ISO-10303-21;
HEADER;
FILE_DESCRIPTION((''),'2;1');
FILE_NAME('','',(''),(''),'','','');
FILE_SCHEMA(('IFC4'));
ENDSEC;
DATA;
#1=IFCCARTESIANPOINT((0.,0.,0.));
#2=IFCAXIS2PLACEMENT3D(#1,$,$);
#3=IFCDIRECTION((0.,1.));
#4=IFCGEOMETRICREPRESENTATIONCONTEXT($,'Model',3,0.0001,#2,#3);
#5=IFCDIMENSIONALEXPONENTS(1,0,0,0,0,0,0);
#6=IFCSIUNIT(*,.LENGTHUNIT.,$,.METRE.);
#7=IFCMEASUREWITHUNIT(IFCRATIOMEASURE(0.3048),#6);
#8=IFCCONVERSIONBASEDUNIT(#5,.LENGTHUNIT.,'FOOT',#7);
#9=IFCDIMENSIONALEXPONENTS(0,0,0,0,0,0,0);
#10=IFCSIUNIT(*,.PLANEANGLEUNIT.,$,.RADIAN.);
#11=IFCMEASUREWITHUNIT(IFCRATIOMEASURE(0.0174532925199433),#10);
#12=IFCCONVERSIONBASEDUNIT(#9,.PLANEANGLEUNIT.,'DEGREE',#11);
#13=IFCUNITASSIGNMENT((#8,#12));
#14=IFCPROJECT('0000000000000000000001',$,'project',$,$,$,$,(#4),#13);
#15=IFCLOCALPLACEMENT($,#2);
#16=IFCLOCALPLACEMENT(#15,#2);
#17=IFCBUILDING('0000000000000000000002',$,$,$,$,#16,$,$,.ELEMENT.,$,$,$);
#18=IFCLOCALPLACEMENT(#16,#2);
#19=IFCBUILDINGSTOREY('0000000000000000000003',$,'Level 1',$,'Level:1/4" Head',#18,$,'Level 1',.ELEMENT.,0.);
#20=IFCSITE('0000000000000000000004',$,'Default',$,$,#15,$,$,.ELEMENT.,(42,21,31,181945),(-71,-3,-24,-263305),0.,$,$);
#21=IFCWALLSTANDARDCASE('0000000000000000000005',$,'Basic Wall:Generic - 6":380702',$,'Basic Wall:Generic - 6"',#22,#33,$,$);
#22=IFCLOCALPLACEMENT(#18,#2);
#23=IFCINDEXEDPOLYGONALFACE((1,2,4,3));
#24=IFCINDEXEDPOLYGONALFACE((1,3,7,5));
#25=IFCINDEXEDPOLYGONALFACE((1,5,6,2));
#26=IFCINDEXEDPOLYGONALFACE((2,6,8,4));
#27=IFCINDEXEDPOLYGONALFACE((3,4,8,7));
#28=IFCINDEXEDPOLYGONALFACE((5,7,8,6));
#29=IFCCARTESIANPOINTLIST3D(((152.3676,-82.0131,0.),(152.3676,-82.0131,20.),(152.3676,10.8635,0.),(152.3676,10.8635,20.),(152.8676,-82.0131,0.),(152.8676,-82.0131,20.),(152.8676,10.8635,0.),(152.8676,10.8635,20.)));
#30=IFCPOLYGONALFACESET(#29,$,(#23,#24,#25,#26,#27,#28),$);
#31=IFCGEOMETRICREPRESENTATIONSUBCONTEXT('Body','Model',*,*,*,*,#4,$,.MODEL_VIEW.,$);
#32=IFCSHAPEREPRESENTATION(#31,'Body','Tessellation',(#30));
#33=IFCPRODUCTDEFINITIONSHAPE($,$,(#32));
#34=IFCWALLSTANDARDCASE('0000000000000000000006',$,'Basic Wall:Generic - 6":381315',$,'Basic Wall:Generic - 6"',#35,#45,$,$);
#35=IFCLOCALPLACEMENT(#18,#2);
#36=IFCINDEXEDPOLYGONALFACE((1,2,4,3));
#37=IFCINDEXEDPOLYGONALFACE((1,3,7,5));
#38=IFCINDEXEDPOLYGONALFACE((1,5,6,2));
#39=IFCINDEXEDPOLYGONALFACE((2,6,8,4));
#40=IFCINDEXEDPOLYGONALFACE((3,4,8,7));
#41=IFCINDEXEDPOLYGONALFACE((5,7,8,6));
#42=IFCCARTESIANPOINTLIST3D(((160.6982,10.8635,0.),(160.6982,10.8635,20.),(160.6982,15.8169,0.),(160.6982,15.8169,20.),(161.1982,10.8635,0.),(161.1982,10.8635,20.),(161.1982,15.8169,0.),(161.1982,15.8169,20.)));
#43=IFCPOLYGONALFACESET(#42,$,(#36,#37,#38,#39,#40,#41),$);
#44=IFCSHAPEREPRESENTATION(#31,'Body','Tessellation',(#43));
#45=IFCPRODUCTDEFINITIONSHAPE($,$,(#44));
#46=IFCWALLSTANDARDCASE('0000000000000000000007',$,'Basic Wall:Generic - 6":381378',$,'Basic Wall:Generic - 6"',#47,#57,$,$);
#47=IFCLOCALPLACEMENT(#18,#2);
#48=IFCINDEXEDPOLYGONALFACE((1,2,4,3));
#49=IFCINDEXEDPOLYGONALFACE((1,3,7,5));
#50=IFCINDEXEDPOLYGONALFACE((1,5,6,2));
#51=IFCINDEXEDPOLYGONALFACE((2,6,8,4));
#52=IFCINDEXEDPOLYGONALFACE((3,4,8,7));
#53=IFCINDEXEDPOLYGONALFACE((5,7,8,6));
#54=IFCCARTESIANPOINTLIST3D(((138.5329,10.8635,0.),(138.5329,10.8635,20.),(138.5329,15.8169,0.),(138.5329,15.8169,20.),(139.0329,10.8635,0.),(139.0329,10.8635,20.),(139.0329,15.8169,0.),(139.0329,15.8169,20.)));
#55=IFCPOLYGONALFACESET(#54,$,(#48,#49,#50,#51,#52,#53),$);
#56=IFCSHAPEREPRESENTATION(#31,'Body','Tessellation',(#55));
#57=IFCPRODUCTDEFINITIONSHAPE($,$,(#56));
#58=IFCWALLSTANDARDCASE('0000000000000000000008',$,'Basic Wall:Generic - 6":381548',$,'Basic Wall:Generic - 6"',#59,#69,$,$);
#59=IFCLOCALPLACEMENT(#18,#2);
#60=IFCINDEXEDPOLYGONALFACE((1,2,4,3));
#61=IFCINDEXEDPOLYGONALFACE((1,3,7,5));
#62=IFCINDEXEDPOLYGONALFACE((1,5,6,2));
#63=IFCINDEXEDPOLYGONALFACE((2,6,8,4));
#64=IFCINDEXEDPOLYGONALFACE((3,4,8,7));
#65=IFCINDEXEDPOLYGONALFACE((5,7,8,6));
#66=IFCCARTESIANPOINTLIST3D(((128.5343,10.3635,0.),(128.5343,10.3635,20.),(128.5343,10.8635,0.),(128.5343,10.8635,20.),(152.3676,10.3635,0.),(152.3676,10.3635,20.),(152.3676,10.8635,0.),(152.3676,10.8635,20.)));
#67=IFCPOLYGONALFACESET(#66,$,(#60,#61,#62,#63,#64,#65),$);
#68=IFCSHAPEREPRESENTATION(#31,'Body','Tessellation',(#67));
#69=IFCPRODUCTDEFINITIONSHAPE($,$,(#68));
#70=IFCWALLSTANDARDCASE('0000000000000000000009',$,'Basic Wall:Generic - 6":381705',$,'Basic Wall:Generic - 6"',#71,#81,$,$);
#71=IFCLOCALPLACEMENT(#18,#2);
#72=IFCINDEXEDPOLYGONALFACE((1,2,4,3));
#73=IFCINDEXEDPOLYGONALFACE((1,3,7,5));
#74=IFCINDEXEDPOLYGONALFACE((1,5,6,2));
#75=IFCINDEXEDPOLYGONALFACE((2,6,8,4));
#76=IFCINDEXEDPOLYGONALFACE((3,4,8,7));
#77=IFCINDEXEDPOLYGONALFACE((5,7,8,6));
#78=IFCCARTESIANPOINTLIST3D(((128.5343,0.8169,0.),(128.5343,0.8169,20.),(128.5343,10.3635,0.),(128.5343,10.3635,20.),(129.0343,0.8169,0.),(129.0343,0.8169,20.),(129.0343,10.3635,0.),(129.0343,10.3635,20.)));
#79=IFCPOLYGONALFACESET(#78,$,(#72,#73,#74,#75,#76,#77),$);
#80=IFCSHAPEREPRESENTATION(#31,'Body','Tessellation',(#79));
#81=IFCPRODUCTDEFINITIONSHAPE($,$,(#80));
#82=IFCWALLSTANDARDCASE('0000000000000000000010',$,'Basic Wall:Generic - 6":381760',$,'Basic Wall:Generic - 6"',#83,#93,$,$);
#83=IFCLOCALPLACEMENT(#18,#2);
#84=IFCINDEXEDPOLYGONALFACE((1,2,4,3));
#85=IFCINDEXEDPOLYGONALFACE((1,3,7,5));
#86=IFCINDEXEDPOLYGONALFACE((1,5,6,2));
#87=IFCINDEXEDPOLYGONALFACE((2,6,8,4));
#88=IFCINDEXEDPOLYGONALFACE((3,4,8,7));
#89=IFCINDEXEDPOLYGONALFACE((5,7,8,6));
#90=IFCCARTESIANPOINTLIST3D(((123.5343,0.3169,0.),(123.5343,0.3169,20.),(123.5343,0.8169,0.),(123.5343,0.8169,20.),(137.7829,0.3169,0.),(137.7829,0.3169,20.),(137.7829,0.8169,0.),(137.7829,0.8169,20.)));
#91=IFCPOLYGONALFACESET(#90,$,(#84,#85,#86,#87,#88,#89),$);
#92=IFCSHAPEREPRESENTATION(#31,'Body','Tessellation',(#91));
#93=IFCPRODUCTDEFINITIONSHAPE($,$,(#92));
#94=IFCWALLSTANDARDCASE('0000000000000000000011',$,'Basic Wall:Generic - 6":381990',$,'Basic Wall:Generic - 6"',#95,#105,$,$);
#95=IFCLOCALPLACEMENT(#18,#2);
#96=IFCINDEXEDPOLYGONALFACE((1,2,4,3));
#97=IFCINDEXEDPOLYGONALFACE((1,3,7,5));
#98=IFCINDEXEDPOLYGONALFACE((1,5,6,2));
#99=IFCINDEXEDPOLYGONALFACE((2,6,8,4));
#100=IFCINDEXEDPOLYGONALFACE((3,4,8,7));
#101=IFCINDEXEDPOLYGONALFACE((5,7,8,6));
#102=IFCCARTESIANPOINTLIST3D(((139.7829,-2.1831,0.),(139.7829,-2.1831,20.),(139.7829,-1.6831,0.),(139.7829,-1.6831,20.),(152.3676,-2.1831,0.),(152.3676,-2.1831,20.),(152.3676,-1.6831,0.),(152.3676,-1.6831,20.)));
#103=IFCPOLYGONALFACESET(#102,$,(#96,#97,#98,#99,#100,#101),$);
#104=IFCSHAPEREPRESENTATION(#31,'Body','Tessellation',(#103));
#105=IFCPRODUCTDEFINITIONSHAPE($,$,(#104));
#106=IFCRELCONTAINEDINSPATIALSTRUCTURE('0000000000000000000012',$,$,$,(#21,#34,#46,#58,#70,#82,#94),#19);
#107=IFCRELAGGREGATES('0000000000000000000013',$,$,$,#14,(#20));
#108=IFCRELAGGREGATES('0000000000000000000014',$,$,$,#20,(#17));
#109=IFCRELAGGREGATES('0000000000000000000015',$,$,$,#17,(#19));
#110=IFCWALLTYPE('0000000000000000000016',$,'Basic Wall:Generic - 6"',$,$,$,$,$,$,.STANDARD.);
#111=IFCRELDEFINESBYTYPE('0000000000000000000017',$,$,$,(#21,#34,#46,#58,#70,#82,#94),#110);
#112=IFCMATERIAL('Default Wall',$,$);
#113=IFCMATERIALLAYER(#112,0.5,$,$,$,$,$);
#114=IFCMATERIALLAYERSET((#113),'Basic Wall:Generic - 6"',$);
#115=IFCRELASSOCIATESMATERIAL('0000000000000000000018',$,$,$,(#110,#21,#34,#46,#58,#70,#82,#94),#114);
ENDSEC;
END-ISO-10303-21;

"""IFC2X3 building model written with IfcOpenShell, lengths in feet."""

from ifc_helpers import new_model, entity, si_unit, converted_unit, direction, frame, frame_2d, origin, place, context, subcontext, project, spatial, rectangle, extrude, material, layer, layer_set, layer_usage, type_object, element, save


model = new_model("IFC2X3")

# Units and contexts
model_context = context("Model", 3, precision=0.0001, world=origin(), true_north=direction((0.0, 1.0)))
body_context = subcontext(model_context, "Body", "Model", "MODEL_VIEW")
ifc_project = project(units=[converted_unit("LENGTHUNIT", "FOOT", entity("IfcRatioMeasure", 0.3048), si_unit("LENGTHUNIT", "METRE"), dimensions=[1, 0, 0, 0, 0, 0, 0]), converted_unit("PLANEANGLEUNIT", "DEGREE", entity("IfcRatioMeasure", 0.0174532925199433), si_unit("PLANEANGLEUNIT", "RADIAN"), dimensions=[0, 0, 0, 0, 0, 0, 0])], contexts=[model_context])

# Site, building, storey
site_placement = place(None, origin())
site = spatial("IfcSite", under=ifc_project, at=site_placement, Name="Default", CompositionType="ELEMENT", RefLatitude=(42, 21, 31, 181945), RefLongitude=(-71, -3, -24, -263305), RefElevation=0.0)
building_placement = place(site_placement, origin())
building = spatial("IfcBuilding", under=site, at=building_placement, CompositionType="ELEMENT")
storey_placement = place(building_placement, origin())
storey = spatial("IfcBuildingStorey", under=building, at=storey_placement, Name="Level 1", ObjectType="Level:1/4\" Head", LongName="Level 1", CompositionType="ELEMENT", Elevation=0.0)

# Walls
ifc_material = material(Name="Default Wall")
ifc_layer_1 = layer(ifc_material, 0.5)
ifc_layer_set_1 = layer_set([ifc_layer_1], Name="Basic Wall:Generic - 6\"")
wall_type_1 = type_object("IfcWallType", Name="Basic Wall:Generic - 6\"", PredefinedType="STANDARD", material=ifc_layer_set_1)
ifc_layer_usage_1 = layer_usage(ifc_layer_set_1, "AXIS2", "NEGATIVE", 0.25)
wall_1_placement = place(storey_placement, frame((152.6176, 10.8635, 0.0), z_axis=(0.0, 0.0, 1.0), x_axis=(0.0, -1.0, 0.0)))
element("IfcWallStandardCase", 1, at=wall_1_placement, inside=storey, type_object=wall_type_1, material=ifc_layer_usage_1, Name="Basic Wall:Generic - 6\":380702", ObjectType="Basic Wall:Generic - 6\"", context=body_context, shape_type="SweptSolid", body=[
    extrude(rectangle(XDim=92.8766, YDim=0.5, at=frame_2d((46.4383, 0.0), x_axis=(-1.0, 0.0))), origin(), (0.0, 0.0, 1.0), 20.0),
])
ifc_layer_usage_2 = layer_usage(ifc_layer_set_1, "AXIS2", "NEGATIVE", 0.25)
wall_2_placement = place(storey_placement, frame((160.9482, 15.8169, 0.0), z_axis=(0.0, 0.0, 1.0), x_axis=(0.0, -1.0, 0.0)))
element("IfcWallStandardCase", 2, at=wall_2_placement, inside=storey, type_object=wall_type_1, material=ifc_layer_usage_2, Name="Basic Wall:Generic - 6\":381315", ObjectType="Basic Wall:Generic - 6\"", context=body_context, shape_type="SweptSolid", body=[
    extrude(rectangle(XDim=4.9534, YDim=0.5, at=frame_2d((2.4767, 0.0), x_axis=(-1.0, 0.0))), origin(), (0.0, 0.0, 1.0), 20.0),
])
ifc_layer_usage_3 = layer_usage(ifc_layer_set_1, "AXIS2", "NEGATIVE", 0.25)
wall_3_placement = place(storey_placement, frame((138.7829, 15.8169, 0.0), z_axis=(0.0, 0.0, 1.0), x_axis=(0.0, -1.0, 0.0)))
element("IfcWallStandardCase", 3, at=wall_3_placement, inside=storey, type_object=wall_type_1, material=ifc_layer_usage_3, Name="Basic Wall:Generic - 6\":381378", ObjectType="Basic Wall:Generic - 6\"", context=body_context, shape_type="SweptSolid", body=[
    extrude(rectangle(XDim=4.9534, YDim=0.5, at=frame_2d((2.4767, 0.0), x_axis=(-1.0, 0.0))), origin(), (0.0, 0.0, 1.0), 20.0),
])
ifc_layer_usage_4 = layer_usage(ifc_layer_set_1, "AXIS2", "NEGATIVE", 0.25)
wall_4_placement = place(storey_placement, frame((152.3676, 10.6135, 0.0), z_axis=(0.0, 0.0, 1.0), x_axis=(-1.0, 0.0, 0.0)))
element("IfcWallStandardCase", 4, at=wall_4_placement, inside=storey, type_object=wall_type_1, material=ifc_layer_usage_4, Name="Basic Wall:Generic - 6\":381548", ObjectType="Basic Wall:Generic - 6\"", context=body_context, shape_type="SweptSolid", body=[
    extrude(rectangle(XDim=23.8333, YDim=0.5, at=frame_2d((11.9167, 0.0), x_axis=(-1.0, 0.0))), origin(), (0.0, 0.0, 1.0), 20.0),
])
ifc_layer_usage_5 = layer_usage(ifc_layer_set_1, "AXIS2", "NEGATIVE", 0.25)
wall_5_placement = place(storey_placement, frame((128.7843, 10.3635, 0.0), z_axis=(0.0, 0.0, 1.0), x_axis=(0.0, -1.0, 0.0)))
element("IfcWallStandardCase", 5, at=wall_5_placement, inside=storey, type_object=wall_type_1, material=ifc_layer_usage_5, Name="Basic Wall:Generic - 6\":381705", ObjectType="Basic Wall:Generic - 6\"", context=body_context, shape_type="SweptSolid", body=[
    extrude(rectangle(XDim=9.5466, YDim=0.5, at=frame_2d((4.7733, 0.0), x_axis=(-1.0, 0.0))), origin(), (0.0, 0.0, 1.0), 20.0),
])
ifc_layer_usage_6 = layer_usage(ifc_layer_set_1, "AXIS2", "NEGATIVE", 0.25)
wall_6_placement = place(storey_placement, frame((137.7829, 0.5669, 0.0), z_axis=(0.0, 0.0, 1.0), x_axis=(-1.0, 0.0, 0.0)))
element("IfcWallStandardCase", 6, at=wall_6_placement, inside=storey, type_object=wall_type_1, material=ifc_layer_usage_6, Name="Basic Wall:Generic - 6\":381760", ObjectType="Basic Wall:Generic - 6\"", context=body_context, shape_type="SweptSolid", body=[
    extrude(rectangle(XDim=14.2486, YDim=0.5, at=frame_2d((7.1243, 0.0), x_axis=(-1.0, 0.0))), origin(), (0.0, 0.0, 1.0), 20.0),
])
ifc_layer_usage_7 = layer_usage(ifc_layer_set_1, "AXIS2", "NEGATIVE", 0.25)
wall_7_placement = place(storey_placement, frame((152.3676, -1.9331, 0.0), z_axis=(0.0, 0.0, 1.0), x_axis=(-1.0, 0.0, 0.0)))
element("IfcWallStandardCase", 7, at=wall_7_placement, inside=storey, type_object=wall_type_1, material=ifc_layer_usage_7, Name="Basic Wall:Generic - 6\":381990", ObjectType="Basic Wall:Generic - 6\"", context=body_context, shape_type="SweptSolid", body=[
    extrude(rectangle(XDim=12.5847, YDim=0.5, at=frame_2d((6.2924, 0.0), x_axis=(-1.0, 0.0))), origin(), (0.0, 0.0, 1.0), 20.0),
])

save(model, "model.ifc")
